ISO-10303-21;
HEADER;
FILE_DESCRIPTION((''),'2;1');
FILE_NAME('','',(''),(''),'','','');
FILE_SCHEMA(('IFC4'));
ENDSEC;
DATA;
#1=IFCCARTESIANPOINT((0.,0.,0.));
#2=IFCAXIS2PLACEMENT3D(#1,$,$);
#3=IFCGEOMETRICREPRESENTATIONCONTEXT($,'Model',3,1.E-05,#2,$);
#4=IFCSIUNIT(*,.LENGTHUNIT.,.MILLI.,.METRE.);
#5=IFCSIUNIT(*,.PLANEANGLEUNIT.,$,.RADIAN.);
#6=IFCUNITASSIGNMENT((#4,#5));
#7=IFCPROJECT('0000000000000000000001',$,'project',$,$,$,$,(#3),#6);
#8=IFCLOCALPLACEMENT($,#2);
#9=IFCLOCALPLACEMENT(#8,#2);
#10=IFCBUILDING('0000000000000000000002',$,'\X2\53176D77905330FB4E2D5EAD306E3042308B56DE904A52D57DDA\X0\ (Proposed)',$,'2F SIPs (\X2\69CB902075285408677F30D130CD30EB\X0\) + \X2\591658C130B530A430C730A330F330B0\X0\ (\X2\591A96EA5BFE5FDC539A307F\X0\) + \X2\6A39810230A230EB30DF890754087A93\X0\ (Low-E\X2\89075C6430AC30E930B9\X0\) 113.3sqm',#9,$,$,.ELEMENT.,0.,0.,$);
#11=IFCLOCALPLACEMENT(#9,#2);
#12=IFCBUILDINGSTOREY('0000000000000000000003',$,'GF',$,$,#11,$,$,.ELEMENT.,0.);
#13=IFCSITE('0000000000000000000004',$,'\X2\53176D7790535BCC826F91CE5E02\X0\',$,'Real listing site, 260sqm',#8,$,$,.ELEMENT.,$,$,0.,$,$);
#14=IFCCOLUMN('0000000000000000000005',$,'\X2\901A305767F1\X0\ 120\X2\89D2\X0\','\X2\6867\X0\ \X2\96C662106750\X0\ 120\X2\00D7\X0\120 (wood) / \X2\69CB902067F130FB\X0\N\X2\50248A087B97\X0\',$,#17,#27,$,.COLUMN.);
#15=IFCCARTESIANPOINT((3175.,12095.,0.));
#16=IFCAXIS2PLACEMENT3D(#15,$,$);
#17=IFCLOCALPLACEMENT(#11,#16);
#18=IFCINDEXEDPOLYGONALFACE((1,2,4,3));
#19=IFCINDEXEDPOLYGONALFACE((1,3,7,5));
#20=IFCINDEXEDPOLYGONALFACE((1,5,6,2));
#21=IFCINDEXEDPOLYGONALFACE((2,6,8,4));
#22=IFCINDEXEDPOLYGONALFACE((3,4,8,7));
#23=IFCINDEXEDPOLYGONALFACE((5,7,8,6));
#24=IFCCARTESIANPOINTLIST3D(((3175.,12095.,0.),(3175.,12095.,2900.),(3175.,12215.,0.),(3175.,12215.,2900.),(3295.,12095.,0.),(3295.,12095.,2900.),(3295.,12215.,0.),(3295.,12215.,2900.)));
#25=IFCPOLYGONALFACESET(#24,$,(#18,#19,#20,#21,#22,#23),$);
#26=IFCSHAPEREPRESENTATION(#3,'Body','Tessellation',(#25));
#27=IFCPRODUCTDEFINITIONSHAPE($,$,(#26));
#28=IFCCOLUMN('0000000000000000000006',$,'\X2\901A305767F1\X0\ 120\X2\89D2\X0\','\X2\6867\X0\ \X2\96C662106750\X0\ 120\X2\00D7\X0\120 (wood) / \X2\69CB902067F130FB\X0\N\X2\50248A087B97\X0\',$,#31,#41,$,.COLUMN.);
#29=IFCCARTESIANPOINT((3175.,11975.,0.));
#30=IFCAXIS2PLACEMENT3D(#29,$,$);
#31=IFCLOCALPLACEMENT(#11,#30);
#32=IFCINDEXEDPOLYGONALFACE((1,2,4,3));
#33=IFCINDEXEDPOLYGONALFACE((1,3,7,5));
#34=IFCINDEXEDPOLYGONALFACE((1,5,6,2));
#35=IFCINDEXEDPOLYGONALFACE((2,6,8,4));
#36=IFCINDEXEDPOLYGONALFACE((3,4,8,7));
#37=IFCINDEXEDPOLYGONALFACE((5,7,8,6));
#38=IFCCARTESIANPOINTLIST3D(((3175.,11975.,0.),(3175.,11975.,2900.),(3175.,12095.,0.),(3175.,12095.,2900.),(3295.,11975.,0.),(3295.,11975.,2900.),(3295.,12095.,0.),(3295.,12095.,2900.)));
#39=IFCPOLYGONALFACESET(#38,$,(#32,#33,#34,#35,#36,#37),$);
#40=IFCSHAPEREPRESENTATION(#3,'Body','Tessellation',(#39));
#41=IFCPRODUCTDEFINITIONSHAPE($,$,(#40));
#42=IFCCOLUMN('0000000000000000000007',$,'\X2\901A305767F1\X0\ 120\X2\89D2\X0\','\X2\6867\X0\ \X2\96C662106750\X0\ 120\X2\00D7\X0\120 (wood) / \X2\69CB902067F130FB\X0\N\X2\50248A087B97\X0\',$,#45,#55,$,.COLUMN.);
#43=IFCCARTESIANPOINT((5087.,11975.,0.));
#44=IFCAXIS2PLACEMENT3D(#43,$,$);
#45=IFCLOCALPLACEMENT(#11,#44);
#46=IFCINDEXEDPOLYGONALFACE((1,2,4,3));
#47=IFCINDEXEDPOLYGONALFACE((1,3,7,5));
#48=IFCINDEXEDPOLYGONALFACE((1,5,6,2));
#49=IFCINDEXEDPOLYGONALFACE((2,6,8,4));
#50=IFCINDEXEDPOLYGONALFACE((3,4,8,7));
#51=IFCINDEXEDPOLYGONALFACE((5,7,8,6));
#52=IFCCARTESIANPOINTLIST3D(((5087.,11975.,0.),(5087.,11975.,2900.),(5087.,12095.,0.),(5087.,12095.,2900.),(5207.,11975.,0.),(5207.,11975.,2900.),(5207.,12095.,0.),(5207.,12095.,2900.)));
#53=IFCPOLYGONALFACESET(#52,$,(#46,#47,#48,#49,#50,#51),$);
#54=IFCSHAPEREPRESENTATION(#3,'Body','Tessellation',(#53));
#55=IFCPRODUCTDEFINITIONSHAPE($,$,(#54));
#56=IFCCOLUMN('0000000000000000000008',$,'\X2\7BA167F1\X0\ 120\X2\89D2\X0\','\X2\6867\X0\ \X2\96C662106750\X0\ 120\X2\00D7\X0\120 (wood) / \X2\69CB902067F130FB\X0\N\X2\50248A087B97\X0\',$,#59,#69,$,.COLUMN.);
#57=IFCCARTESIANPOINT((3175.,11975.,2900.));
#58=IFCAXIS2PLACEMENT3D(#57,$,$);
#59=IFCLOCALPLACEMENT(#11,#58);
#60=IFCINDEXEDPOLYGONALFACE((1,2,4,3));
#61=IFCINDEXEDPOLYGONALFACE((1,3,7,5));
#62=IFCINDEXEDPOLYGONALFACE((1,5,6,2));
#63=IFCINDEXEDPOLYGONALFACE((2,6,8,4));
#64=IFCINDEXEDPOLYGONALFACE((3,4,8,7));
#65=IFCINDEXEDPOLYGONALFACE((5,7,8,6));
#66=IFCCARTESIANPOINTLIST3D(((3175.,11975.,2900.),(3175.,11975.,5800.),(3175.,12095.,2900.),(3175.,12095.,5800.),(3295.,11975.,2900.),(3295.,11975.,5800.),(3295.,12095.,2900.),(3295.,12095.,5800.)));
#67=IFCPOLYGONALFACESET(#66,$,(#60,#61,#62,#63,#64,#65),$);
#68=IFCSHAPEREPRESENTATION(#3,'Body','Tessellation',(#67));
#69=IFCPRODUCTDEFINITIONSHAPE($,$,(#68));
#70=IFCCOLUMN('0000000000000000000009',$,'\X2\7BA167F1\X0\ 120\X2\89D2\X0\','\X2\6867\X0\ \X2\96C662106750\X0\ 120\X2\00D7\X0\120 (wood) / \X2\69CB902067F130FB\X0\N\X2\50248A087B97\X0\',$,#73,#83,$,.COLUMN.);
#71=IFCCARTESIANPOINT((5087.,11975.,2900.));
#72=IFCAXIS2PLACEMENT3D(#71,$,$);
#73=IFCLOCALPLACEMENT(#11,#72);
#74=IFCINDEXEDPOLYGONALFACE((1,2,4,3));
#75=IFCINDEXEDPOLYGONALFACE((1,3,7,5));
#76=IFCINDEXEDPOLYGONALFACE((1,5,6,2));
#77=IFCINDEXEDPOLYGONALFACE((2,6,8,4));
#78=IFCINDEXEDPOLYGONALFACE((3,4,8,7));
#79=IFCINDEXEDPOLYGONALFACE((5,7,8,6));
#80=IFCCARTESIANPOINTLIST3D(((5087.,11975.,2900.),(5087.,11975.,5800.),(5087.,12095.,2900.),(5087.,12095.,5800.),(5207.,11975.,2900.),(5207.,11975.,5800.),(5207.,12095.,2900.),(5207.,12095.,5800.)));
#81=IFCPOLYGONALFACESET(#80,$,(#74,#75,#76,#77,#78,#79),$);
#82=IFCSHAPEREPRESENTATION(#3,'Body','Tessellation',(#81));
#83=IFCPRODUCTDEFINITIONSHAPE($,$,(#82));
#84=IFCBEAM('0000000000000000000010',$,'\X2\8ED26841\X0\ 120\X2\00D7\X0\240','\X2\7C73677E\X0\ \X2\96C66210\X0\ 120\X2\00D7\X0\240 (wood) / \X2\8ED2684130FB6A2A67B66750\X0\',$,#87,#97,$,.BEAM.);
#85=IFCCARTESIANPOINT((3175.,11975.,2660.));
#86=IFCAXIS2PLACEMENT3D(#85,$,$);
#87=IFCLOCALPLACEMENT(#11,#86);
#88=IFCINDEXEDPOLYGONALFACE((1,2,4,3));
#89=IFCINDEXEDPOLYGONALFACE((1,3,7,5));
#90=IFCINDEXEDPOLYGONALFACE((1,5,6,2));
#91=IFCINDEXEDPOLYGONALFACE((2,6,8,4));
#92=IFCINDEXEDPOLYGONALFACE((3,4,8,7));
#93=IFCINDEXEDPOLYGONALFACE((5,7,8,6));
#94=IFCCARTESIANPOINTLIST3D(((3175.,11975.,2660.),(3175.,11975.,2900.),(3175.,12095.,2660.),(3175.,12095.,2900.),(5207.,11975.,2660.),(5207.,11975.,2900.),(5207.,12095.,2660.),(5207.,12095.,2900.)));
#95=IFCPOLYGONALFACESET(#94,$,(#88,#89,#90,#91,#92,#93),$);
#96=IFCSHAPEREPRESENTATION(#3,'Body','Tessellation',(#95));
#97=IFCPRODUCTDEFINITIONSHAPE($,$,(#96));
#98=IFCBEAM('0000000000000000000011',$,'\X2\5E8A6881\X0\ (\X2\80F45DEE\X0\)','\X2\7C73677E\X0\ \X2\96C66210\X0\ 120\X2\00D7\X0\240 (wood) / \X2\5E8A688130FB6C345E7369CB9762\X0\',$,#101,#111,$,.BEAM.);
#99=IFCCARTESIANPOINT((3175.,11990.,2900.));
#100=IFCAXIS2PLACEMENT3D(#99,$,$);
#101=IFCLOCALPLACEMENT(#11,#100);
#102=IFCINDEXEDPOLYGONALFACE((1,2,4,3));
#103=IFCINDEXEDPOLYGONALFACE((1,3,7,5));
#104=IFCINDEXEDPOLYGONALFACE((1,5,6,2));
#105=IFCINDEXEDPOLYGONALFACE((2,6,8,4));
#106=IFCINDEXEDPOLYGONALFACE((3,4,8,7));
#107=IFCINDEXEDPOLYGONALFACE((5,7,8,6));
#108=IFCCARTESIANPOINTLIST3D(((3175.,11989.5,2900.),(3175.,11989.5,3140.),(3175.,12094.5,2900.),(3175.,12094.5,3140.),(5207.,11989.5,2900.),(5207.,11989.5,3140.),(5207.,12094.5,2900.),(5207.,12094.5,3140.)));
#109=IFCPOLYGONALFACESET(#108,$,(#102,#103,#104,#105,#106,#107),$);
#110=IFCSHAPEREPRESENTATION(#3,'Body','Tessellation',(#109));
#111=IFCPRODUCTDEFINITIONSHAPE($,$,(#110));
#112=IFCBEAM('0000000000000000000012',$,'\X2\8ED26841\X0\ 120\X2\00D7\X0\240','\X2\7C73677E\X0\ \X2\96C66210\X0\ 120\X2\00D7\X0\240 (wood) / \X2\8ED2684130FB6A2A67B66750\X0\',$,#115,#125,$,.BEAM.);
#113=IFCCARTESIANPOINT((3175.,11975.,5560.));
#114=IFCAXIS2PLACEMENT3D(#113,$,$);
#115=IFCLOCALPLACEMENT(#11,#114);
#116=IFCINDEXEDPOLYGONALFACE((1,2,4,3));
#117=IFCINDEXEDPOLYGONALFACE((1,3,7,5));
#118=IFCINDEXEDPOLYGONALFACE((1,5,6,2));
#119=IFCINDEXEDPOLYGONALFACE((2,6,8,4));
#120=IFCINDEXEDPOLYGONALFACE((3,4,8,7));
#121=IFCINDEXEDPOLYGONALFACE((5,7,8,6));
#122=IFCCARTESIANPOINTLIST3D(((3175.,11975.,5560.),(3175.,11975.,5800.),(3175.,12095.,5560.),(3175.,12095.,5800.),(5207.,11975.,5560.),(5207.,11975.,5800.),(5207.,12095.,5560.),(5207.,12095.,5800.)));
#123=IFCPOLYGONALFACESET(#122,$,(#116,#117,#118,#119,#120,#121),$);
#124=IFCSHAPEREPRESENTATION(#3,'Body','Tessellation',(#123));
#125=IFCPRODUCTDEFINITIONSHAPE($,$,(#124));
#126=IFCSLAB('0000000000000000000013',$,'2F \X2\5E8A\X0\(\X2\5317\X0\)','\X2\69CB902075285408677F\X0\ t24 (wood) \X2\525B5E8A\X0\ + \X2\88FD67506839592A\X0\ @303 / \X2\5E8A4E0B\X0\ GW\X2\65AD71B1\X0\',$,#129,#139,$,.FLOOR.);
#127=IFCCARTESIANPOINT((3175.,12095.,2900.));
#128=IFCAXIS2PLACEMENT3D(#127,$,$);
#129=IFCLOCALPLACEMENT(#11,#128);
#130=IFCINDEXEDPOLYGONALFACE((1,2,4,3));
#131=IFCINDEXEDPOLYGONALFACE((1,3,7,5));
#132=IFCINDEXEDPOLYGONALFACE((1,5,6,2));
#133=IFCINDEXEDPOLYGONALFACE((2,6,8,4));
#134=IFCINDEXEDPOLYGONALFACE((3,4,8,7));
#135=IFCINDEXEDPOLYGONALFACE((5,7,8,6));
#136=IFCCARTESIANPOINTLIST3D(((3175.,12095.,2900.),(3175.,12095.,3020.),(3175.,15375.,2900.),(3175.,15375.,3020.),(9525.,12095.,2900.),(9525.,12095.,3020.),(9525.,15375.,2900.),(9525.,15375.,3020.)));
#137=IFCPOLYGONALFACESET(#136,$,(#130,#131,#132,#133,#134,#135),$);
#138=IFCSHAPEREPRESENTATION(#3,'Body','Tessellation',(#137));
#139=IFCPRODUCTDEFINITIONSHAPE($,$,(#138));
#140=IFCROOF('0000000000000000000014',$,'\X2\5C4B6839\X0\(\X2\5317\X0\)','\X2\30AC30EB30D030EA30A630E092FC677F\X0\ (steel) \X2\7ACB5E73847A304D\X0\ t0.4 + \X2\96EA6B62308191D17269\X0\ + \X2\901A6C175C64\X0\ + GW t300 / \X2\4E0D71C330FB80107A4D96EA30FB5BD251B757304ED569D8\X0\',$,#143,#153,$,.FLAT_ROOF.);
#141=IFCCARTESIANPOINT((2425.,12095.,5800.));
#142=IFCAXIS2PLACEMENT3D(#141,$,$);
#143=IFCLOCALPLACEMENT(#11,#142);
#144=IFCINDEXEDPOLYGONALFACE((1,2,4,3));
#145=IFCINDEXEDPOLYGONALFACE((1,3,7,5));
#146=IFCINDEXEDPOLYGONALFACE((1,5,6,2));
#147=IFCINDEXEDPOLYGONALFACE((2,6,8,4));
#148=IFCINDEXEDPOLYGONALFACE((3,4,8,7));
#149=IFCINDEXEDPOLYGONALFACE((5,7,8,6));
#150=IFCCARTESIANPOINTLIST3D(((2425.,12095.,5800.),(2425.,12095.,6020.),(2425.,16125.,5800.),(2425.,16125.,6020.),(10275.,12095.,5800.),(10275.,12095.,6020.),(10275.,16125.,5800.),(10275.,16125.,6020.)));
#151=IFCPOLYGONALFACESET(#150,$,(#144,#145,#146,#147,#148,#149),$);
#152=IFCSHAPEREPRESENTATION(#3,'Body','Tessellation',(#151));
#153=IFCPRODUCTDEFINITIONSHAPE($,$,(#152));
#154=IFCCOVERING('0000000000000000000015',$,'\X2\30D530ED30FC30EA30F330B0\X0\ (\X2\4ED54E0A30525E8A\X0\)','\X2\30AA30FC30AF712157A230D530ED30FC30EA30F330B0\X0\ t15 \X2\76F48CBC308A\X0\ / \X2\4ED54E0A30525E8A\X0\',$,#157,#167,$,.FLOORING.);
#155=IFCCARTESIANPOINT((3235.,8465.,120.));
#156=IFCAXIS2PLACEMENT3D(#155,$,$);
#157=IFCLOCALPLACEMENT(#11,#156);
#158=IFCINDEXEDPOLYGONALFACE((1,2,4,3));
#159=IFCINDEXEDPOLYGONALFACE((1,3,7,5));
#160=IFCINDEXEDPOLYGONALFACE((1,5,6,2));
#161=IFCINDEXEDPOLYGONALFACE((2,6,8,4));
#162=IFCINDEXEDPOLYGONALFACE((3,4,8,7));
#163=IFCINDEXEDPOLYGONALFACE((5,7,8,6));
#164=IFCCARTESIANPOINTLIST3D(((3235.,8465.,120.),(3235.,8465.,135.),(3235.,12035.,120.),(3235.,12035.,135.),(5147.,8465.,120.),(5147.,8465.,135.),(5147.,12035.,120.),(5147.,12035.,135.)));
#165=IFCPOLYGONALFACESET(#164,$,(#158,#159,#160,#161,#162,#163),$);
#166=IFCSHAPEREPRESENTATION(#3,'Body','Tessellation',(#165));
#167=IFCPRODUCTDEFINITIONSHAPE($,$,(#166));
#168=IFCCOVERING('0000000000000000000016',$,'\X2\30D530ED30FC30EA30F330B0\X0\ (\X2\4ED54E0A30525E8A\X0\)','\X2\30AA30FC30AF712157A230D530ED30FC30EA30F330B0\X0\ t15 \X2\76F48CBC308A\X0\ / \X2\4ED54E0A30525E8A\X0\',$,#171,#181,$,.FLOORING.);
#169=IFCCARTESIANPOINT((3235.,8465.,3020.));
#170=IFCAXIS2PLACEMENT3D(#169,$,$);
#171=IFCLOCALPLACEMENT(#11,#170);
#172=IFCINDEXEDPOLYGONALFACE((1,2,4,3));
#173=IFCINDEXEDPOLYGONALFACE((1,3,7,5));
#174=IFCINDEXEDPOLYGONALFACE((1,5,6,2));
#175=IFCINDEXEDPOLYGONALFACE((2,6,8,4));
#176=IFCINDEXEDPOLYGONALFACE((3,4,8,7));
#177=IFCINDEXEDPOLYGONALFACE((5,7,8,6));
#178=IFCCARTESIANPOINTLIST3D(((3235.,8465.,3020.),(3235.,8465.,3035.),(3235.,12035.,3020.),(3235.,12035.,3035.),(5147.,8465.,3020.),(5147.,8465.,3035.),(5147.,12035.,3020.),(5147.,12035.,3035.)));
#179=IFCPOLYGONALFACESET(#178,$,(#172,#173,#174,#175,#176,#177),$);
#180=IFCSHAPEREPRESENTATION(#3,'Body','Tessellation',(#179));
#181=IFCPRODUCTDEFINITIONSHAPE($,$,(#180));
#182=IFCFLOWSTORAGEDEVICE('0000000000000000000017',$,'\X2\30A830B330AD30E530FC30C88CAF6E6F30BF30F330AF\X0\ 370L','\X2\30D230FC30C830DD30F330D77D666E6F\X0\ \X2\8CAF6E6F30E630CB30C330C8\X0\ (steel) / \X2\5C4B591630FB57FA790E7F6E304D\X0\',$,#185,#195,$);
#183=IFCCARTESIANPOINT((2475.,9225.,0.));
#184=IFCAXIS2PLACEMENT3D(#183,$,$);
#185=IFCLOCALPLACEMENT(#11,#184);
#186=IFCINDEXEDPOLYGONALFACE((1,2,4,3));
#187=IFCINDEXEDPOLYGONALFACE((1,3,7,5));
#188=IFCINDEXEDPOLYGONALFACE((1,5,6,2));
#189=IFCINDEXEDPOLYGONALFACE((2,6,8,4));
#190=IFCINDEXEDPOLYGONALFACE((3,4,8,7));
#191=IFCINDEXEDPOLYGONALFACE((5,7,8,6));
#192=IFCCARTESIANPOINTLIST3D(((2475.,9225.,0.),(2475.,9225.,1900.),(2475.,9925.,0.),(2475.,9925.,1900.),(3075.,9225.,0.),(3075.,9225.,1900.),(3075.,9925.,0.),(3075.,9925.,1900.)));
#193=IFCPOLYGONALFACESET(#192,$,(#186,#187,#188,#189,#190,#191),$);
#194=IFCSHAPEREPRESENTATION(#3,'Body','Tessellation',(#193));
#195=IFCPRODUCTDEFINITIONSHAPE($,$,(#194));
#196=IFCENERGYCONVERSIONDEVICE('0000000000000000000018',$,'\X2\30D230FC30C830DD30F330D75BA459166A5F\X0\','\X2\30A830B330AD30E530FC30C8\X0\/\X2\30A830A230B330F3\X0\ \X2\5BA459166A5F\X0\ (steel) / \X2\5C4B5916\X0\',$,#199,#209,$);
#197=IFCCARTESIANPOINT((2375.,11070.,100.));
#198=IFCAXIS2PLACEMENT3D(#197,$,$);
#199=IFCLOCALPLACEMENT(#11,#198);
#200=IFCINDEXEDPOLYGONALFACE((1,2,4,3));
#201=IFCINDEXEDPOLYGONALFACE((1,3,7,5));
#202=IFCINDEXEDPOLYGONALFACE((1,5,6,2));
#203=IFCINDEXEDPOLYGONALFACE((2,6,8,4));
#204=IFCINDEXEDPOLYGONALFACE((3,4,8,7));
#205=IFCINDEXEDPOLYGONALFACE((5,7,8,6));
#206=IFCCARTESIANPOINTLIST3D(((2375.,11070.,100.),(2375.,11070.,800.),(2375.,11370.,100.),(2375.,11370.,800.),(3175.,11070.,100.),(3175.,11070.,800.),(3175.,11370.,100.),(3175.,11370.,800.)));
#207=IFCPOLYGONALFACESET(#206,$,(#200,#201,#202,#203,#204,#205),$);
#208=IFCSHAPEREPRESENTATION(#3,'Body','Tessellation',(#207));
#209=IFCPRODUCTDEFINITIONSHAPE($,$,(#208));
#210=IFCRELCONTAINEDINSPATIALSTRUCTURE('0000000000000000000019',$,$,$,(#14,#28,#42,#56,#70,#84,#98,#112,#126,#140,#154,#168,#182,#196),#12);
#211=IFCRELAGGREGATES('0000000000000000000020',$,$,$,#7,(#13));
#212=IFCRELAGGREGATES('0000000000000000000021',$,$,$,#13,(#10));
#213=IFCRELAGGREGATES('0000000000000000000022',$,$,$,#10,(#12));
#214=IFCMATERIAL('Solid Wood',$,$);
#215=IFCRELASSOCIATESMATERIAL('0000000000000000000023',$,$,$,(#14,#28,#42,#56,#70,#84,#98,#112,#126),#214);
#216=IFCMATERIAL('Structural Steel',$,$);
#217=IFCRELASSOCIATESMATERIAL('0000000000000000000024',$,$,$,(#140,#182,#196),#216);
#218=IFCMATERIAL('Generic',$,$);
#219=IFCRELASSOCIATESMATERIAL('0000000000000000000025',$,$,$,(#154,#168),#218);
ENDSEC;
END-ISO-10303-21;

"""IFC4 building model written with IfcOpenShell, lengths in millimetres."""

from ifc_helpers import new_model, si_unit, frame, frame_2d, origin, place, context, project, spatial, rectangle, extrude, material, element, save


model = new_model("IFC4")

# Units and contexts
model_context = context("Model", 3, precision=1e-05, world=origin())
ifc_project = project(units=[si_unit("LENGTHUNIT", "METRE", prefix="MILLI"), si_unit("PLANEANGLEUNIT", "RADIAN")], contexts=[model_context])

# Site, building, storey
site_placement = place(None, origin())
site = spatial("IfcSite", under=ifc_project, at=site_placement, Name="北海道富良野市", ObjectType="Real listing site, 260sqm", CompositionType="ELEMENT", RefElevation=0.0)
building_placement = place(site_placement, origin())
building = spatial("IfcBuilding", under=site, at=building_placement, Name="北海道・中庭のある回遊動線 (Proposed)", ObjectType="2F SIPs (構造用合板パネル) + 外壁サイディング (多雪対応厚み) + 樹脂アルミ複合窓 (Low-E複層ガラス) 113.3sqm", CompositionType="ELEMENT", ElevationOfRefHeight=0.0, ElevationOfTerrain=0.0)
storey_placement = place(building_placement, origin())
storey = spatial("IfcBuildingStorey", under=building, at=storey_placement, Name="GF", CompositionType="ELEMENT", Elevation=0.0)

# Columns
ifc_material_1 = material(Name="Solid Wood")
column_1_placement = place(storey_placement, frame((3175.0, 12095.0, 0.0)))
element("IfcColumn", 1, at=column_1_placement, inside=storey, material=ifc_material_1, Name="通し柱 120角", Description="桧 集成材 120×120 (wood) / 構造柱・N値計算", PredefinedType="COLUMN", context=model_context, shape_type="SweptSolid", body=[
    extrude(rectangle(XDim=120.0, YDim=120.0, at=frame_2d((60.0, 60.0))), frame((3175.0, 12095.0, 0.0)), (0.0, 0.0, 1.0), 2900.0),
])
column_2_placement = place(storey_placement, frame((3175.0, 11975.0, 0.0)))
element("IfcColumn", 2, at=column_2_placement, inside=storey, material=ifc_material_1, Name="通し柱 120角", Description="桧 集成材 120×120 (wood) / 構造柱・N値計算", PredefinedType="COLUMN", context=model_context, shape_type="SweptSolid", body=[
    extrude(rectangle(XDim=120.0, YDim=120.0, at=frame_2d((60.0, 60.0))), frame((3175.0, 11975.0, 0.0)), (0.0, 0.0, 1.0), 2900.0),
])
column_3_placement = place(storey_placement, frame((5087.0, 11975.0, 0.0)))
element("IfcColumn", 3, at=column_3_placement, inside=storey, material=ifc_material_1, Name="通し柱 120角", Description="桧 集成材 120×120 (wood) / 構造柱・N値計算", PredefinedType="COLUMN", context=model_context, shape_type="SweptSolid", body=[
    extrude(rectangle(XDim=120.0, YDim=120.0, at=frame_2d((60.0, 60.0))), frame((5087.0, 11975.0, 0.0)), (0.0, 0.0, 1.0), 2900.0),
])
column_4_placement = place(storey_placement, frame((3175.0, 11975.0, 2900.0)))
element("IfcColumn", 4, at=column_4_placement, inside=storey, material=ifc_material_1, Name="管柱 120角", Description="桧 集成材 120×120 (wood) / 構造柱・N値計算", PredefinedType="COLUMN", context=model_context, shape_type="SweptSolid", body=[
    extrude(rectangle(XDim=120.0, YDim=120.0, at=frame_2d((60.0, 60.0))), frame((3175.0, 11975.0, 2900.0)), (0.0, 0.0, 1.0), 2900.0),
])
column_5_placement = place(storey_placement, frame((5087.0, 11975.0, 2900.0)))
element("IfcColumn", 5, at=column_5_placement, inside=storey, material=ifc_material_1, Name="管柱 120角", Description="桧 集成材 120×120 (wood) / 構造柱・N値計算", PredefinedType="COLUMN", context=model_context, shape_type="SweptSolid", body=[
    extrude(rectangle(XDim=120.0, YDim=120.0, at=frame_2d((60.0, 60.0))), frame((5087.0, 11975.0, 2900.0)), (0.0, 0.0, 1.0), 2900.0),
])

# Beams
beam_1_placement = place(storey_placement, frame((3175.0, 11975.0, 2660.0)))
element("IfcBeam", 6, at=beam_1_placement, inside=storey, material=ifc_material_1, Name="軒桁 120×240", Description="米松 集成 120×240 (wood) / 軒桁・横架材", PredefinedType="BEAM", context=model_context, shape_type="SweptSolid", body=[
    extrude(rectangle(XDim=2032.0, YDim=120.0, at=frame_2d((1016.0, 60.0))), frame((3175.0, 11975.0, 2660.0)), (0.0, 0.0, 1.0), 240.0),
])
beam_2_placement = place(storey_placement, frame((3175.0, 11990.0, 2900.0)))
element("IfcBeam", 7, at=beam_2_placement, inside=storey, material=ifc_material_1, Name="床梁 (胴差)", Description="米松 集成 120×240 (wood) / 床梁・水平構面", PredefinedType="BEAM", context=model_context, shape_type="SweptSolid", body=[
    extrude(rectangle(XDim=2032.0, YDim=105.0, at=frame_2d((1016.0, 52.0))), frame((3175.0, 11990.0, 2900.0)), (0.0, 0.0, 1.0), 240.0),
])
beam_3_placement = place(storey_placement, frame((3175.0, 11975.0, 5560.0)))
element("IfcBeam", 8, at=beam_3_placement, inside=storey, material=ifc_material_1, Name="軒桁 120×240", Description="米松 集成 120×240 (wood) / 軒桁・横架材", PredefinedType="BEAM", context=model_context, shape_type="SweptSolid", body=[
    extrude(rectangle(XDim=2032.0, YDim=120.0, at=frame_2d((1016.0, 60.0))), frame((3175.0, 11975.0, 5560.0)), (0.0, 0.0, 1.0), 240.0),
])

# Slab
slab_1_placement = place(storey_placement, frame((3175.0, 12095.0, 2900.0)))
element("IfcSlab", 9, at=slab_1_placement, inside=storey, material=ifc_material_1, Name="2F 床(北)", Description="構造用合板 t24 (wood) 剛床 + 製材根太 @303 / 床下 GW断熱", PredefinedType="FLOOR", context=model_context, shape_type="SweptSolid", body=[
    extrude(rectangle(XDim=6350.0, YDim=3280.0, at=frame_2d((3175.0, 1640.0))), frame((3175.0, 12095.0, 2900.0)), (0.0, 0.0, 1.0), 120.0),
])

# Roof
ifc_material_2 = material(Name="Structural Steel")
for number, where, name in (
    (10, (2425.0, 12095.0, 5800.0), "屋根(北)"),
):
    element("IfcRoof", number, at=place(storey_placement, frame(where)), inside=storey, material=ifc_material_2, Name=name, Description="ガルバリウム鋼板 (steel) 立平葺き t0.4 + 雪止め金物 + 通気層 + GW t300 / 不燃・耐積雪・寒冷地仕様", PredefinedType="FLAT_ROOF", context=model_context, shape_type="SweptSolid", body=[
        extrude(rectangle(XDim=7850.0, YDim=4030.0, at=frame_2d((3925.0, 2015.0))), frame((2425.0, 12095.0, 5800.0)), (0.0, 0.0, 1.0), 220.0),
    ])

# Coverings
ifc_material_3 = material(Name="Generic")
covering_1_placement = place(storey_placement, frame((3235.0, 8465.0, 120.0)))
element("IfcCovering", 11, at=covering_1_placement, inside=storey, material=ifc_material_3, Name="フローリング (仕上げ床)", Description="オーク無垢フローリング t15 直貼り / 仕上げ床", PredefinedType="FLOORING", context=model_context, shape_type="SweptSolid", body=[
    extrude(rectangle(XDim=1912.0, YDim=3570.0, at=frame_2d((956.0, 1785.0))), frame((3235.0, 8465.0, 120.0)), (0.0, 0.0, 1.0), 15.0),
])
covering_2_placement = place(storey_placement, frame((3235.0, 8465.0, 3020.0)))
element("IfcCovering", 12, at=covering_2_placement, inside=storey, material=ifc_material_3, Name="フローリング (仕上げ床)", Description="オーク無垢フローリング t15 直貼り / 仕上げ床", PredefinedType="FLOORING", context=model_context, shape_type="SweptSolid", body=[
    extrude(rectangle(XDim=1912.0, YDim=3570.0, at=frame_2d((956.0, 1785.0))), frame((3235.0, 8465.0, 3020.0)), (0.0, 0.0, 1.0), 15.0),
])

# Flow storage device
flow_storage_device_placement = place(storey_placement, frame((2475.0, 9225.0, 0.0)))
element("IfcFlowStorageDevice", 13, at=flow_storage_device_placement, inside=storey, material=ifc_material_2, Name="エコキュート貯湯タンク 370L", Description="ヒートポンプ給湯 貯湯ユニット (steel) / 屋外・基礎置き", context=model_context, shape_type="SweptSolid", body=[
    extrude(rectangle(XDim=600.0, YDim=700.0, at=frame_2d((300.0, 350.0))), frame((2475.0, 9225.0, 0.0)), (0.0, 0.0, 1.0), 1900.0),
])

# Energy conversion device
energy_conversion_device_placement = place(storey_placement, frame((2375.0, 11070.0, 100.0)))
element("IfcEnergyConversionDevice", 14, at=energy_conversion_device_placement, inside=storey, material=ifc_material_2, Name="ヒートポンプ室外機", Description="エコキュート/エアコン 室外機 (steel) / 屋外", context=model_context, shape_type="SweptSolid", body=[
    extrude(rectangle(XDim=800.0, YDim=300.0, at=frame_2d((400.0, 150.0))), frame((2375.0, 11070.0, 100.0)), (0.0, 0.0, 1.0), 700.0),
])

save(model, "model.ifc")
